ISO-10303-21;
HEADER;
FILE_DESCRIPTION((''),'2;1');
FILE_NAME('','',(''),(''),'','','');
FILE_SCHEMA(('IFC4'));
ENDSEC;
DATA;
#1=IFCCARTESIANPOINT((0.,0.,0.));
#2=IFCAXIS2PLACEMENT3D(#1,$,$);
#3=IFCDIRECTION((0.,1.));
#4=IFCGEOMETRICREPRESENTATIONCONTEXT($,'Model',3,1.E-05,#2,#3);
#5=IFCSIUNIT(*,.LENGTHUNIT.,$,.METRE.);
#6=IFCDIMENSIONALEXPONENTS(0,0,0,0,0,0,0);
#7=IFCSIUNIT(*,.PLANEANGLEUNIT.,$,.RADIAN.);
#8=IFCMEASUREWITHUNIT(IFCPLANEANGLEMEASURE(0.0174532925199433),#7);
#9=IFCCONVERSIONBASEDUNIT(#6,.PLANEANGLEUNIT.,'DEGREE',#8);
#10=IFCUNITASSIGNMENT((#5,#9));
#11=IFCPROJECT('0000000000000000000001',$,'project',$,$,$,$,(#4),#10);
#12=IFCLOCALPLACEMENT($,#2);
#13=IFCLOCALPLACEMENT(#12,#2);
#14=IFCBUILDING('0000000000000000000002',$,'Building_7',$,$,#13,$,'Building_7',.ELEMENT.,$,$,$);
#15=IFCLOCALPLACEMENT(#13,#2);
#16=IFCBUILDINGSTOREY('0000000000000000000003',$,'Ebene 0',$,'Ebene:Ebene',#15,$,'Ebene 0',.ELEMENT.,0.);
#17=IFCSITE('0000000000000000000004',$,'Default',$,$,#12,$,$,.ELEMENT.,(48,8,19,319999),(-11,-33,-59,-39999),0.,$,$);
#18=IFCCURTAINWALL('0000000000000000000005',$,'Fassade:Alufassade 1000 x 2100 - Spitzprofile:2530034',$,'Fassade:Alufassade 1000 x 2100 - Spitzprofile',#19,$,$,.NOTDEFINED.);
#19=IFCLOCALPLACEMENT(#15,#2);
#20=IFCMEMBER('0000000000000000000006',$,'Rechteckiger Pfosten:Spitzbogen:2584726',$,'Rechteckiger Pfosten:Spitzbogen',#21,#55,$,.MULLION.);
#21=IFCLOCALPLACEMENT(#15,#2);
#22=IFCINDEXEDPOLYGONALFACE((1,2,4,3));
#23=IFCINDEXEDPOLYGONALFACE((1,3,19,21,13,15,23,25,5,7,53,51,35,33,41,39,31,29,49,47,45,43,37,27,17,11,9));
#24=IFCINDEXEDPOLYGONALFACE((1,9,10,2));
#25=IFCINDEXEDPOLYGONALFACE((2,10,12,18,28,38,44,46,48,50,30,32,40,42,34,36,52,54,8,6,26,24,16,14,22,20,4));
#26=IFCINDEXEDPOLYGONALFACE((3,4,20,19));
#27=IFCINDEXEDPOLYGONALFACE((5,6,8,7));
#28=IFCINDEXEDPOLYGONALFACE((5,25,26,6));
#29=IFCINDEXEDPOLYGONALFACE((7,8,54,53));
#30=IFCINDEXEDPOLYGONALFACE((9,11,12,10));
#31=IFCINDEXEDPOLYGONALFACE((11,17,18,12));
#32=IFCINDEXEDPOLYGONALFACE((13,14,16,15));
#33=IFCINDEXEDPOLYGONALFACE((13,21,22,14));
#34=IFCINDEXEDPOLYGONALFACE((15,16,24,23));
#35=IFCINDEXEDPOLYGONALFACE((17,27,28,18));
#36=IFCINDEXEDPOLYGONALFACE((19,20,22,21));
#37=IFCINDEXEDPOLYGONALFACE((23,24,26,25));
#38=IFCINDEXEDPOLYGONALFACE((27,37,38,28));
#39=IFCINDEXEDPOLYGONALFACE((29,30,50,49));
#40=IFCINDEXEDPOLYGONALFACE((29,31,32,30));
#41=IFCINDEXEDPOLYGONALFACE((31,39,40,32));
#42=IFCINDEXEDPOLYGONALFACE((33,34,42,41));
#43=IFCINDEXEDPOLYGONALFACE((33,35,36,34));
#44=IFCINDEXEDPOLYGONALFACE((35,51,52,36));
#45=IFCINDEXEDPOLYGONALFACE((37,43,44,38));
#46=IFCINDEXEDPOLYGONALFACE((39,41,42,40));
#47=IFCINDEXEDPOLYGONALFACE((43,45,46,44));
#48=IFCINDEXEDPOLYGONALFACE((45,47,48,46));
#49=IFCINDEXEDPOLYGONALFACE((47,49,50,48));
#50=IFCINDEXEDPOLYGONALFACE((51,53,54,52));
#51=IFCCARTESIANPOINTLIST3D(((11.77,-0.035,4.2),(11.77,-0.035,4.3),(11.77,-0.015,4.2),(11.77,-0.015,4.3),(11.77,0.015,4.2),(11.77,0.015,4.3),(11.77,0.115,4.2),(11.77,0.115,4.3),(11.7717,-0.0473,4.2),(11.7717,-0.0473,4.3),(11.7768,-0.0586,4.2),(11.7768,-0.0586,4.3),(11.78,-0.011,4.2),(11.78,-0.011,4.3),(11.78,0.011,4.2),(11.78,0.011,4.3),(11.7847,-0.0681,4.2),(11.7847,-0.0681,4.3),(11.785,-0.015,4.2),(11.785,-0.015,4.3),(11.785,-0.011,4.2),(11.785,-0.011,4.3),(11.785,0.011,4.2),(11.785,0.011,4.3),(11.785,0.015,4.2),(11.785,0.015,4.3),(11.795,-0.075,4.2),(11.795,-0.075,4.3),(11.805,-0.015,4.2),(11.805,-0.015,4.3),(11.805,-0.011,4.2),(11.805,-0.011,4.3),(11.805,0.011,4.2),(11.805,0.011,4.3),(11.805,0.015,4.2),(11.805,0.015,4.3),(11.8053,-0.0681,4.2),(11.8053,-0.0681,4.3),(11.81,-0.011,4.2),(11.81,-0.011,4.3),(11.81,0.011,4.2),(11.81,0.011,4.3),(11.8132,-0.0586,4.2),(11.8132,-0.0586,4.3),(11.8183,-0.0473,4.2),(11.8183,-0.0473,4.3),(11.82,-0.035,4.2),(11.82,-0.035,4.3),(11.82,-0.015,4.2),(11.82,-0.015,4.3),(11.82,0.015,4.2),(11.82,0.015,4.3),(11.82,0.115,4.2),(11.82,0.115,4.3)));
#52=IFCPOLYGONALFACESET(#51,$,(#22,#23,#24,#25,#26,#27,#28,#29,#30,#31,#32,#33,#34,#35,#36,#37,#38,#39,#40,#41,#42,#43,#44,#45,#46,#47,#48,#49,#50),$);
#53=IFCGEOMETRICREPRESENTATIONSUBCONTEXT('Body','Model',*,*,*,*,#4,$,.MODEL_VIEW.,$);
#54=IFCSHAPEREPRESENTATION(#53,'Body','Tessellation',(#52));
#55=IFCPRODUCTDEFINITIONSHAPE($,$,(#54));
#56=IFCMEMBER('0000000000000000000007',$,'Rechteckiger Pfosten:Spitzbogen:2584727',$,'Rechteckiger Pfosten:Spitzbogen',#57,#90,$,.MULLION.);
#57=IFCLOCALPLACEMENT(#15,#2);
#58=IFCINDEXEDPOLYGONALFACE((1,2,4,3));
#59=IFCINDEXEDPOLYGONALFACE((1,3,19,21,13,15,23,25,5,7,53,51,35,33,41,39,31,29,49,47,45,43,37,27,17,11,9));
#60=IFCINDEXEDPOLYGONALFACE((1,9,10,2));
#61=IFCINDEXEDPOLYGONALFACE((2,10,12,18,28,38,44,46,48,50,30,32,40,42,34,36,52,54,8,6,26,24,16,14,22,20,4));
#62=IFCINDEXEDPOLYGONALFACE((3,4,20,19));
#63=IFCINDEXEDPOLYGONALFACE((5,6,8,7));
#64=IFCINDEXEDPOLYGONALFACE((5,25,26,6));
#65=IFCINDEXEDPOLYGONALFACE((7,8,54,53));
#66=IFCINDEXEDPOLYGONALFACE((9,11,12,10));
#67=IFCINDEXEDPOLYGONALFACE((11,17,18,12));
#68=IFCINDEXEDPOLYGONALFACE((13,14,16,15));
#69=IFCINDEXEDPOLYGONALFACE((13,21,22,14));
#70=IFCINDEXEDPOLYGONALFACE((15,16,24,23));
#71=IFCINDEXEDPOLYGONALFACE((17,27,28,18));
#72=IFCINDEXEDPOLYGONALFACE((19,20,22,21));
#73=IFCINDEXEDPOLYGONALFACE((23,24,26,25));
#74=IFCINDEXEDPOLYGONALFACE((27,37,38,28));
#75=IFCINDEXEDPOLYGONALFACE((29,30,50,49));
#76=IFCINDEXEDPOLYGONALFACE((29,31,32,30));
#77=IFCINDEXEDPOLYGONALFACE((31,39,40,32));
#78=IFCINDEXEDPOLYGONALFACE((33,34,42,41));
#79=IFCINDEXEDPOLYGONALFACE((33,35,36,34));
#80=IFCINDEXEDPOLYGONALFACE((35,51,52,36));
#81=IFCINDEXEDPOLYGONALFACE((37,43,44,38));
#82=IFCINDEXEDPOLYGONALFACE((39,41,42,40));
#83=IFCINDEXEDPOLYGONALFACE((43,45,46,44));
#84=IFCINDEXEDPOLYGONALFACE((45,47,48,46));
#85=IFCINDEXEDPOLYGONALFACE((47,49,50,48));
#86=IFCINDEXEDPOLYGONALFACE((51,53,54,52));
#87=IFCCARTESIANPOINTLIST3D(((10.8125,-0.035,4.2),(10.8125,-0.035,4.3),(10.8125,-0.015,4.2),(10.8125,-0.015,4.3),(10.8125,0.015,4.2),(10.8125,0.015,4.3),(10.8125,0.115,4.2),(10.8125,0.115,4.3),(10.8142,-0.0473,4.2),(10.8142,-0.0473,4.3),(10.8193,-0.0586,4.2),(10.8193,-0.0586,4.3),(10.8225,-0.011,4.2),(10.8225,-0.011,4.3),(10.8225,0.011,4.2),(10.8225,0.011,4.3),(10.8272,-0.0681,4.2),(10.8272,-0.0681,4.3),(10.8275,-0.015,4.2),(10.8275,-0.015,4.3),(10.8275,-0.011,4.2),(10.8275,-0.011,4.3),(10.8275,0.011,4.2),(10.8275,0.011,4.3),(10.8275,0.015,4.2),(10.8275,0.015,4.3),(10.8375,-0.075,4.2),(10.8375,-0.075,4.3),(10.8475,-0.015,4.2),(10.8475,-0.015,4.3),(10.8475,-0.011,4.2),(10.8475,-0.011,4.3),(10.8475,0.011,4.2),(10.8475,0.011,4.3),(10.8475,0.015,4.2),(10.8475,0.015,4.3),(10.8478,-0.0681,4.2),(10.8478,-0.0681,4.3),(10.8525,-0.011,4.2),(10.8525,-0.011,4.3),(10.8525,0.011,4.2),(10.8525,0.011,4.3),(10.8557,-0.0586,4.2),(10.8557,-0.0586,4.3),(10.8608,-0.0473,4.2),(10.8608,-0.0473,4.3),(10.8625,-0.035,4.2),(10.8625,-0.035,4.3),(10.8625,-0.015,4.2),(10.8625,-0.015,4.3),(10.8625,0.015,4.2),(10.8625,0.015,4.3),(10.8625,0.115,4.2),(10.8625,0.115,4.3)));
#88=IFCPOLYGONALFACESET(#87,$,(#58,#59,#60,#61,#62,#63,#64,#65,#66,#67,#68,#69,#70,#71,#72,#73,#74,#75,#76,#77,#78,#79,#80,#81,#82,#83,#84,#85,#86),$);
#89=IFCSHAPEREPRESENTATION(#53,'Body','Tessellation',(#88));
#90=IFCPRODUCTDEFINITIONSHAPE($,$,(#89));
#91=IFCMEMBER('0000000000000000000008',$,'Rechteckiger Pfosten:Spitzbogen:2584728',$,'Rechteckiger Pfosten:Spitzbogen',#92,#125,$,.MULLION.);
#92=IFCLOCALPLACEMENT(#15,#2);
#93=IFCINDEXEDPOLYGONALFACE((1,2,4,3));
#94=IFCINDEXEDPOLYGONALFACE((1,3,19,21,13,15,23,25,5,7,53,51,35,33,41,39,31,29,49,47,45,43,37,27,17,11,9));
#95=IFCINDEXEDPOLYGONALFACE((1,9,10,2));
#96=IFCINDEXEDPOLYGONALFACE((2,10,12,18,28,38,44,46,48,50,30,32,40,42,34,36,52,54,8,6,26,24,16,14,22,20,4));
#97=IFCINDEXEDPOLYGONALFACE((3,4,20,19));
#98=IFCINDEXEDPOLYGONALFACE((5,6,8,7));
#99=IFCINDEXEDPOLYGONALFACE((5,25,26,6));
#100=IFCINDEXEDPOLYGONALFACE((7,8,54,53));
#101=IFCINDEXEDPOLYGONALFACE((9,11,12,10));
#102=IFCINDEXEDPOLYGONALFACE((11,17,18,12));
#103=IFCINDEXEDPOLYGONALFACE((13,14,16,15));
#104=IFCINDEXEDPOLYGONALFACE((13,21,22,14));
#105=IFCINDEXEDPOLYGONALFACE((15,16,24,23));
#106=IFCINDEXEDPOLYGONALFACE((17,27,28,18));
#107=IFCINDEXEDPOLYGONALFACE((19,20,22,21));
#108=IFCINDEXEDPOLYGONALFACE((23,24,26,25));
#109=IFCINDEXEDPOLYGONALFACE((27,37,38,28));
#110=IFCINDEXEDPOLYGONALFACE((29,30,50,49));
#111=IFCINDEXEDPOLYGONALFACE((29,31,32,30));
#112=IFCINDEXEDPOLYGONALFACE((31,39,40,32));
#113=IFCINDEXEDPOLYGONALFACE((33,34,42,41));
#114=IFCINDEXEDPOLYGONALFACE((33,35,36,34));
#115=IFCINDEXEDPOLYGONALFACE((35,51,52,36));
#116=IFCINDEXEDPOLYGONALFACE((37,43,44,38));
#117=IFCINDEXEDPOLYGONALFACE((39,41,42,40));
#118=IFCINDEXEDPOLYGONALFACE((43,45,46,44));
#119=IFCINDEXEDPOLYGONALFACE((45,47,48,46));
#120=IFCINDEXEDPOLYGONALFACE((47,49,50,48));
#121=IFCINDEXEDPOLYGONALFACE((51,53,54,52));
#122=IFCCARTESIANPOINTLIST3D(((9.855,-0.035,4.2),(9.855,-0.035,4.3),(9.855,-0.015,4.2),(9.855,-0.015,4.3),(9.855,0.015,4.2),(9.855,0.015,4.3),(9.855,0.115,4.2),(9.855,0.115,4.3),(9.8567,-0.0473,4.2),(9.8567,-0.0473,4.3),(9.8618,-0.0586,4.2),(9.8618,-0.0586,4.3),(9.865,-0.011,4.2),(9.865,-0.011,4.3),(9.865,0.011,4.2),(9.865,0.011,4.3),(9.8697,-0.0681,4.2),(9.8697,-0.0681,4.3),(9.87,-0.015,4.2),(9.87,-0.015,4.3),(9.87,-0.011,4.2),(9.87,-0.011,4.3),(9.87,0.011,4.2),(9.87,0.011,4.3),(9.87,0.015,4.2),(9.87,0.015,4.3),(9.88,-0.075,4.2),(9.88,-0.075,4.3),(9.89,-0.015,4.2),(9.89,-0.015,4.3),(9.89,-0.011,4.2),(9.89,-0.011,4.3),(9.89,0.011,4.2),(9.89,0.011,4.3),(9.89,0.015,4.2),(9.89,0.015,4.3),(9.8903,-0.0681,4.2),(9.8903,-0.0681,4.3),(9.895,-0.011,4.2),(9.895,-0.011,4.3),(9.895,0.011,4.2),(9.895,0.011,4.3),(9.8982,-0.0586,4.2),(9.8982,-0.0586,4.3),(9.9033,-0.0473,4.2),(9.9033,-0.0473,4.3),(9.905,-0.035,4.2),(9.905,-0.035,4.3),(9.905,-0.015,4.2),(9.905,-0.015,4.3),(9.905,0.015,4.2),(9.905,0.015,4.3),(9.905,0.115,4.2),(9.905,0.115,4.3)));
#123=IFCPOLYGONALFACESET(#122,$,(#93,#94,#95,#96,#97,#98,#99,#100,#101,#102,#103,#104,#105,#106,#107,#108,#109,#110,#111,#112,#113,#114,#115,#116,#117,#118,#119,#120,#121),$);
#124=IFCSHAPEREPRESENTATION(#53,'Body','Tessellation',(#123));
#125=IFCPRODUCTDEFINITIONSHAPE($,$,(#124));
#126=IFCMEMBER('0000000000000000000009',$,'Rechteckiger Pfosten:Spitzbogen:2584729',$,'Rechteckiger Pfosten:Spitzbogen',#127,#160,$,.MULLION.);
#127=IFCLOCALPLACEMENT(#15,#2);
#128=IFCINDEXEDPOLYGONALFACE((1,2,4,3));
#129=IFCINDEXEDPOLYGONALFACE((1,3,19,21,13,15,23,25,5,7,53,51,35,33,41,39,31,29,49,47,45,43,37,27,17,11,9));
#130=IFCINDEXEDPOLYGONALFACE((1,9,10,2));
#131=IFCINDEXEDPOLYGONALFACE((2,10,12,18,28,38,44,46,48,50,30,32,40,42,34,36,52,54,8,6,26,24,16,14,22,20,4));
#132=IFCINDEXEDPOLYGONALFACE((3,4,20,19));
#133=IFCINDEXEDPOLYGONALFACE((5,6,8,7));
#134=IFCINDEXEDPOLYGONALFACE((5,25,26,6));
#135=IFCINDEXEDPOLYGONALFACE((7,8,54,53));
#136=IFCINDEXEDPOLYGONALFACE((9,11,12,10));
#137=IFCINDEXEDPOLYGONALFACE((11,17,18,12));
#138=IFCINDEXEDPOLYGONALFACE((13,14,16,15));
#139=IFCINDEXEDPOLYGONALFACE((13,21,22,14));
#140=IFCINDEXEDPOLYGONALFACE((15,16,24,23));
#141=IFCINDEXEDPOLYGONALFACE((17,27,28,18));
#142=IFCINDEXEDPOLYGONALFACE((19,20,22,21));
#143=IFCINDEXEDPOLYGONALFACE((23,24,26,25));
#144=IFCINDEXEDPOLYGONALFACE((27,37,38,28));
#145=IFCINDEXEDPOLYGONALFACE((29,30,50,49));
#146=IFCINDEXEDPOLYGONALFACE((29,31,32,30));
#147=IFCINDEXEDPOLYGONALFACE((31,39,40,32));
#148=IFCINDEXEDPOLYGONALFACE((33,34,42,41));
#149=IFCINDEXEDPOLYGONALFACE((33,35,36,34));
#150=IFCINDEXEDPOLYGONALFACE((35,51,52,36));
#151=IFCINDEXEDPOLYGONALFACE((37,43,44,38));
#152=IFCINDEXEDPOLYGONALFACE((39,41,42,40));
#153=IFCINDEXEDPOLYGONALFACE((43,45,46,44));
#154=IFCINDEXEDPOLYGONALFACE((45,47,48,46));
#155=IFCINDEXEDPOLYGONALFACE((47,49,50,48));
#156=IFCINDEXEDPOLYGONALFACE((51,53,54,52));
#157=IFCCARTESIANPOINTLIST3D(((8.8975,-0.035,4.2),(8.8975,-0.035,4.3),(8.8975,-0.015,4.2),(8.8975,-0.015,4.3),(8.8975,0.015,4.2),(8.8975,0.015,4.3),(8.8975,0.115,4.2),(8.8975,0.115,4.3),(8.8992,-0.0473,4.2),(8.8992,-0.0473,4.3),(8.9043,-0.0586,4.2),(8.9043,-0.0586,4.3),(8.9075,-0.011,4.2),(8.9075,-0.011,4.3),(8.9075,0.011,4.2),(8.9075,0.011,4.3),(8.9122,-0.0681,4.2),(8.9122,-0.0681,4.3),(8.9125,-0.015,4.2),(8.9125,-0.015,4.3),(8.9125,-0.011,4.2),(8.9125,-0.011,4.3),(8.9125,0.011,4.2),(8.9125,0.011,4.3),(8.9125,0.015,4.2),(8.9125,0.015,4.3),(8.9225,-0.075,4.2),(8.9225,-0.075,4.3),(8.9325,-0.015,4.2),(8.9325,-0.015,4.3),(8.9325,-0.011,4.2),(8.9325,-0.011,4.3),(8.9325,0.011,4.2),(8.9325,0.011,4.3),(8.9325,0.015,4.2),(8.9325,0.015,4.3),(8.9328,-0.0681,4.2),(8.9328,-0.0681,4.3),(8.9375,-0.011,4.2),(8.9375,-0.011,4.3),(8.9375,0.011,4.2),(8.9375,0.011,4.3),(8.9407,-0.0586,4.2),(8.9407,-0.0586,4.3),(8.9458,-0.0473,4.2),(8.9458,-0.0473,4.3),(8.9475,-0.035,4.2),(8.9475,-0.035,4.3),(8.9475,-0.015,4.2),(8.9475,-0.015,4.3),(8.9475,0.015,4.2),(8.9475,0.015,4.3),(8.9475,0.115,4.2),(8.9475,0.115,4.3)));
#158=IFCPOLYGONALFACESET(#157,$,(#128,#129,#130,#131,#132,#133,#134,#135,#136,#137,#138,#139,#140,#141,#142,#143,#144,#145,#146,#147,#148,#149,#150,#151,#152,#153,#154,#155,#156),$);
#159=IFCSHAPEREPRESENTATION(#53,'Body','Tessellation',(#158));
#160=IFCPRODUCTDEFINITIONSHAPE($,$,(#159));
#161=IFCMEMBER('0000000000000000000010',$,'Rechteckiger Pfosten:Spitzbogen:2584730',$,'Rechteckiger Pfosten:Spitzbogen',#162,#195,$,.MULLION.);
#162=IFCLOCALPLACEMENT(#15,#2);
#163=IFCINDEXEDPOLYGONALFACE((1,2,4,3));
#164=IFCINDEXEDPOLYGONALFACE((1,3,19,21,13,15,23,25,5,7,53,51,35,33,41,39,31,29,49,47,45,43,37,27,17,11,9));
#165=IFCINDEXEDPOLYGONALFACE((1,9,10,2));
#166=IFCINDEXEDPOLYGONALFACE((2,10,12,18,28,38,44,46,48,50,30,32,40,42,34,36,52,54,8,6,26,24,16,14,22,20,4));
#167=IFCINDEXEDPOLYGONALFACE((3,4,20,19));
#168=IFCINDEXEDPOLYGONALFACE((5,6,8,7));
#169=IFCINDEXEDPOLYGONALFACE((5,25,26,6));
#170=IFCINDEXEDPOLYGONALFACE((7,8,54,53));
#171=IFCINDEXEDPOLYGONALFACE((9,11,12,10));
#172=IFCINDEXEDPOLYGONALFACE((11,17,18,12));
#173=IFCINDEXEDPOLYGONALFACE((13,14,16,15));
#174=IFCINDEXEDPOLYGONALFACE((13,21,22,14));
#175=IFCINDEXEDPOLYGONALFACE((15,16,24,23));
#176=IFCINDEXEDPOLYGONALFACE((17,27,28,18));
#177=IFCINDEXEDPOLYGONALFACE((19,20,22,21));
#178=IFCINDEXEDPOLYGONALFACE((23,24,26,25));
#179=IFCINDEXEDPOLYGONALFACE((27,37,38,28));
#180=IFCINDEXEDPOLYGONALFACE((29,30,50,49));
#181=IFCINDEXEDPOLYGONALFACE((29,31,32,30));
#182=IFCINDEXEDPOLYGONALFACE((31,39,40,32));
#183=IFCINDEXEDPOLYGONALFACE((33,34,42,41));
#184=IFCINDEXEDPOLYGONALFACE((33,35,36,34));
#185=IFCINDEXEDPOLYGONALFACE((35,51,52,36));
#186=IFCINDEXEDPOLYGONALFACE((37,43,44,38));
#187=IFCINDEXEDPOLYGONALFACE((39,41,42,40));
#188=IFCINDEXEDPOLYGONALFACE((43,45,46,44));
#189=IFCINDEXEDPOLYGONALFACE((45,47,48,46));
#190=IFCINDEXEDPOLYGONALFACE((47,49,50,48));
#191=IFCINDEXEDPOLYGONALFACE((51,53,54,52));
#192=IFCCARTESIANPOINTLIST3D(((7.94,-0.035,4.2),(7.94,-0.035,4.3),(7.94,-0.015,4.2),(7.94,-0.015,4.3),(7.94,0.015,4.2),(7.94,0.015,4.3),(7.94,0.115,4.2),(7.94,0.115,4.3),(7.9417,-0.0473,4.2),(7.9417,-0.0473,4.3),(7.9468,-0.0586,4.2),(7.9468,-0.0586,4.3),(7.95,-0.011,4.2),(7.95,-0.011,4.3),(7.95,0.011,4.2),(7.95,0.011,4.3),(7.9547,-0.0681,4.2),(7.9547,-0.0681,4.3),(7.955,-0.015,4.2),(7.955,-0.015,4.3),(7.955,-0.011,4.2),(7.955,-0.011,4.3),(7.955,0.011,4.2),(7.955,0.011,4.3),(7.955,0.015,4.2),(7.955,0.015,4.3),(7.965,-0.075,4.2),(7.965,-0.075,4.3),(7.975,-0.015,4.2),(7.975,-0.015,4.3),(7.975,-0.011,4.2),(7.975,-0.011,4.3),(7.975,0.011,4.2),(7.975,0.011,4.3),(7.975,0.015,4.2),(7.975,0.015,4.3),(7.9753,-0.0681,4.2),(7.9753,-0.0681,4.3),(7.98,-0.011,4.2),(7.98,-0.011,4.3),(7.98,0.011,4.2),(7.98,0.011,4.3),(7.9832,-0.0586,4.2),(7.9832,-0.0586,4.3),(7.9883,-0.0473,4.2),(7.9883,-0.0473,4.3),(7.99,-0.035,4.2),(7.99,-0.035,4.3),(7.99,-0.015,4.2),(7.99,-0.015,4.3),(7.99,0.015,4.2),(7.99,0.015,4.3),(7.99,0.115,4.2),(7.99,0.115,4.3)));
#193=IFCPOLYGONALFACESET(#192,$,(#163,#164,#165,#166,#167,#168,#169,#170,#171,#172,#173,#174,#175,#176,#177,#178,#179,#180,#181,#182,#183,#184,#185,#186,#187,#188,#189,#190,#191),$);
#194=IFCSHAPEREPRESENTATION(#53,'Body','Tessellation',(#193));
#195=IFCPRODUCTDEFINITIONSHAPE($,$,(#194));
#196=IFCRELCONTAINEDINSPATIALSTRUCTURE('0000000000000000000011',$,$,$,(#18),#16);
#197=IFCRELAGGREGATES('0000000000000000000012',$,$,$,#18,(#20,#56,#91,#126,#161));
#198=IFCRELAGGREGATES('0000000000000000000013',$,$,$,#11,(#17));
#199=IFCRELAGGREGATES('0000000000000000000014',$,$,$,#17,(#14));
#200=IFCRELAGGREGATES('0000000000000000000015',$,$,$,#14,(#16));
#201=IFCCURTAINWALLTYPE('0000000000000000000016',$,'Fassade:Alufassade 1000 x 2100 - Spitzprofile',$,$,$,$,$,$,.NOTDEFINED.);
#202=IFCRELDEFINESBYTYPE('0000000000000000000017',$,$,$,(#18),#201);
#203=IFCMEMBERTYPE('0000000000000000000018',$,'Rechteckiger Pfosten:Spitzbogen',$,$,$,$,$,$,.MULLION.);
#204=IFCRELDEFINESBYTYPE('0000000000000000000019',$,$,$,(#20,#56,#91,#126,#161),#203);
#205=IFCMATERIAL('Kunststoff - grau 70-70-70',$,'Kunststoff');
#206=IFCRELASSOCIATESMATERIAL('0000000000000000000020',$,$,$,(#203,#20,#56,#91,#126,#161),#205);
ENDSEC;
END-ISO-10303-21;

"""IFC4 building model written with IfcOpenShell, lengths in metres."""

from ifc_helpers import new_model, entity, si_unit, converted_unit, direction, frame, origin, place, context, subcontext, project, spatial, line, arc, indexed_curve, outline, extrude, source, transform, mapped, material, type_object, type_shapes, element, aggregate, save


model = new_model("IFC4")

# Units and contexts
model_context = context("Model", 3, precision=1e-05, world=origin(), true_north=direction((0.0, 1.0)))
body_context = subcontext(model_context, "Body", "Model", "MODEL_VIEW")
ifc_project = project(units=[si_unit("LENGTHUNIT", "METRE"), converted_unit("PLANEANGLEUNIT", "DEGREE", entity("IfcPlaneAngleMeasure", 0.0174532925199433), si_unit("PLANEANGLEUNIT", "RADIAN"), dimensions=[0, 0, 0, 0, 0, 0, 0])], contexts=[model_context])

# Site, building, storey
site_placement = place(None, origin())
site = spatial("IfcSite", under=ifc_project, at=site_placement, Name="Default", CompositionType="ELEMENT", RefLatitude=(48, 8, 19, 319999), RefLongitude=(-11, -33, -59, -39999), RefElevation=0.0)
building_placement = place(site_placement, origin())
building = spatial("IfcBuilding", under=site, at=building_placement, Name="Building_7", LongName="Building_7", CompositionType="ELEMENT")
storey_placement = place(building_placement, origin())
storey = spatial("IfcBuildingStorey", under=building, at=storey_placement, Name="Ebene 0", ObjectType="Ebene:Ebene", LongName="Ebene 0", CompositionType="ELEMENT", Elevation=0.0)

# Curtain wall, members
curtain_wall_type = type_object("IfcCurtainWallType", Name="Fassade:Alufassade 1000 x 2100 - Spitzprofile", PredefinedType="NOTDEFINED")
curtain_wall_placement = place(storey_placement, origin())
curtain_wall = element("IfcCurtainWall", 1, at=curtain_wall_placement, inside=storey, type_object=curtain_wall_type, Name="Fassade:Alufassade 1000 x 2100 - Spitzprofile:2530034", ObjectType="Fassade:Alufassade 1000 x 2100 - Spitzprofile", PredefinedType="NOTDEFINED")
ifc_material = material(Name="Kunststoff - grau 70-70-70", Category="Kunststoff")
member_type_1 = type_object("IfcMemberType", Name="Rechteckiger Pfosten:Spitzbogen", PredefinedType="MULLION", material=ifc_material)
shared_shape_1 = source(origin(), body_context, "Body", "SweptSolid", [
    extrude(outline(indexed_curve([(-0.111, -0.025), (-0.011, -0.025), (-0.011, -0.01), (-0.007, -0.01), (-0.007, -0.015), (0.015, -0.015), (0.015, -0.01), (0.019, -0.01), (0.019, -0.025), (0.039, -0.025), (0.0626, -0.0182), (0.079, 0.0), (0.0626, 0.0182), (0.039, 0.025), (0.019, 0.025), (0.019, 0.01), (0.015, 0.01), (0.015, 0.015), (-0.007, 0.015), (-0.007, 0.01), (-0.011, 0.01), (-0.011, 0.025), (-0.111, 0.025)], segments=[line(1, 2, 3, 4, 5, 6, 7, 8, 9, 10), arc(10, 11, 12), arc(12, 13, 14), line(14, 15, 16, 17, 18, 19, 20, 21, 22, 23, 1)], self_intersect=False)), frame((0.0, 0.004, -0.1), z_axis=(0.0, 0.0, 1.0), x_axis=(0.0, -1.0, 0.0)), (0.0, 0.0, 1.0), 0.1),
])
type_shapes(member_type_1, [shared_shape_1])
member_1_placement = place(curtain_wall_placement, frame((11.795, 0.0, 4.2), z_axis=(0.0, 0.0, -1.0), x_axis=(-1.0, 0.0, 0.0)))
member_1 = element("IfcMember", 2, at=member_1_placement, type_object=member_type_1, material=ifc_material, Name="Rechteckiger Pfosten:Spitzbogen:2584726", ObjectType="Rechteckiger Pfosten:Spitzbogen", PredefinedType="MULLION", context=body_context, shape_type="MappedRepresentation", body=[
    mapped(shared_shape_1, transform((0.0, 0.0, 0.0), scale=1.0)),
])
member_2_placement = place(curtain_wall_placement, frame((10.8375, 0.0, 4.2), z_axis=(0.0, 0.0, -1.0), x_axis=(-1.0, 0.0, 0.0)))
member_2 = element("IfcMember", 3, at=member_2_placement, type_object=member_type_1, material=ifc_material, Name="Rechteckiger Pfosten:Spitzbogen:2584727", ObjectType="Rechteckiger Pfosten:Spitzbogen", PredefinedType="MULLION", context=body_context, shape_type="MappedRepresentation", body=[
    mapped(shared_shape_1, transform((0.0, 0.0, 0.0), scale=1.0)),
])
member_3_placement = place(curtain_wall_placement, frame((9.88, 0.0, 4.2), z_axis=(0.0, 0.0, -1.0), x_axis=(-1.0, 0.0, 0.0)))
member_3 = element("IfcMember", 4, at=member_3_placement, type_object=member_type_1, material=ifc_material, Name="Rechteckiger Pfosten:Spitzbogen:2584728", ObjectType="Rechteckiger Pfosten:Spitzbogen", PredefinedType="MULLION", context=body_context, shape_type="MappedRepresentation", body=[
    mapped(shared_shape_1, transform((0.0, 0.0, 0.0), scale=1.0)),
])
member_4_placement = place(curtain_wall_placement, frame((8.9225, 0.0, 4.2), z_axis=(0.0, 0.0, -1.0), x_axis=(-1.0, 0.0, 0.0)))
member_4 = element("IfcMember", 5, at=member_4_placement, type_object=member_type_1, material=ifc_material, Name="Rechteckiger Pfosten:Spitzbogen:2584729", ObjectType="Rechteckiger Pfosten:Spitzbogen", PredefinedType="MULLION", context=body_context, shape_type="MappedRepresentation", body=[
    mapped(shared_shape_1, transform((0.0, 0.0, 0.0), scale=1.0)),
])
member_5_placement = place(curtain_wall_placement, frame((7.965, 0.0, 4.2), z_axis=(0.0, 0.0, -1.0), x_axis=(-1.0, 0.0, 0.0)))
member_5 = element("IfcMember", 6, at=member_5_placement, type_object=member_type_1, material=ifc_material, Name="Rechteckiger Pfosten:Spitzbogen:2584730", ObjectType="Rechteckiger Pfosten:Spitzbogen", PredefinedType="MULLION", context=body_context, shape_type="MappedRepresentation", body=[
    mapped(shared_shape_1, transform((0.0, 0.0, 0.0), scale=1.0)),
])
aggregate(curtain_wall, [member_1, member_2, member_3, member_4, member_5])

save(model, "model.ifc")
